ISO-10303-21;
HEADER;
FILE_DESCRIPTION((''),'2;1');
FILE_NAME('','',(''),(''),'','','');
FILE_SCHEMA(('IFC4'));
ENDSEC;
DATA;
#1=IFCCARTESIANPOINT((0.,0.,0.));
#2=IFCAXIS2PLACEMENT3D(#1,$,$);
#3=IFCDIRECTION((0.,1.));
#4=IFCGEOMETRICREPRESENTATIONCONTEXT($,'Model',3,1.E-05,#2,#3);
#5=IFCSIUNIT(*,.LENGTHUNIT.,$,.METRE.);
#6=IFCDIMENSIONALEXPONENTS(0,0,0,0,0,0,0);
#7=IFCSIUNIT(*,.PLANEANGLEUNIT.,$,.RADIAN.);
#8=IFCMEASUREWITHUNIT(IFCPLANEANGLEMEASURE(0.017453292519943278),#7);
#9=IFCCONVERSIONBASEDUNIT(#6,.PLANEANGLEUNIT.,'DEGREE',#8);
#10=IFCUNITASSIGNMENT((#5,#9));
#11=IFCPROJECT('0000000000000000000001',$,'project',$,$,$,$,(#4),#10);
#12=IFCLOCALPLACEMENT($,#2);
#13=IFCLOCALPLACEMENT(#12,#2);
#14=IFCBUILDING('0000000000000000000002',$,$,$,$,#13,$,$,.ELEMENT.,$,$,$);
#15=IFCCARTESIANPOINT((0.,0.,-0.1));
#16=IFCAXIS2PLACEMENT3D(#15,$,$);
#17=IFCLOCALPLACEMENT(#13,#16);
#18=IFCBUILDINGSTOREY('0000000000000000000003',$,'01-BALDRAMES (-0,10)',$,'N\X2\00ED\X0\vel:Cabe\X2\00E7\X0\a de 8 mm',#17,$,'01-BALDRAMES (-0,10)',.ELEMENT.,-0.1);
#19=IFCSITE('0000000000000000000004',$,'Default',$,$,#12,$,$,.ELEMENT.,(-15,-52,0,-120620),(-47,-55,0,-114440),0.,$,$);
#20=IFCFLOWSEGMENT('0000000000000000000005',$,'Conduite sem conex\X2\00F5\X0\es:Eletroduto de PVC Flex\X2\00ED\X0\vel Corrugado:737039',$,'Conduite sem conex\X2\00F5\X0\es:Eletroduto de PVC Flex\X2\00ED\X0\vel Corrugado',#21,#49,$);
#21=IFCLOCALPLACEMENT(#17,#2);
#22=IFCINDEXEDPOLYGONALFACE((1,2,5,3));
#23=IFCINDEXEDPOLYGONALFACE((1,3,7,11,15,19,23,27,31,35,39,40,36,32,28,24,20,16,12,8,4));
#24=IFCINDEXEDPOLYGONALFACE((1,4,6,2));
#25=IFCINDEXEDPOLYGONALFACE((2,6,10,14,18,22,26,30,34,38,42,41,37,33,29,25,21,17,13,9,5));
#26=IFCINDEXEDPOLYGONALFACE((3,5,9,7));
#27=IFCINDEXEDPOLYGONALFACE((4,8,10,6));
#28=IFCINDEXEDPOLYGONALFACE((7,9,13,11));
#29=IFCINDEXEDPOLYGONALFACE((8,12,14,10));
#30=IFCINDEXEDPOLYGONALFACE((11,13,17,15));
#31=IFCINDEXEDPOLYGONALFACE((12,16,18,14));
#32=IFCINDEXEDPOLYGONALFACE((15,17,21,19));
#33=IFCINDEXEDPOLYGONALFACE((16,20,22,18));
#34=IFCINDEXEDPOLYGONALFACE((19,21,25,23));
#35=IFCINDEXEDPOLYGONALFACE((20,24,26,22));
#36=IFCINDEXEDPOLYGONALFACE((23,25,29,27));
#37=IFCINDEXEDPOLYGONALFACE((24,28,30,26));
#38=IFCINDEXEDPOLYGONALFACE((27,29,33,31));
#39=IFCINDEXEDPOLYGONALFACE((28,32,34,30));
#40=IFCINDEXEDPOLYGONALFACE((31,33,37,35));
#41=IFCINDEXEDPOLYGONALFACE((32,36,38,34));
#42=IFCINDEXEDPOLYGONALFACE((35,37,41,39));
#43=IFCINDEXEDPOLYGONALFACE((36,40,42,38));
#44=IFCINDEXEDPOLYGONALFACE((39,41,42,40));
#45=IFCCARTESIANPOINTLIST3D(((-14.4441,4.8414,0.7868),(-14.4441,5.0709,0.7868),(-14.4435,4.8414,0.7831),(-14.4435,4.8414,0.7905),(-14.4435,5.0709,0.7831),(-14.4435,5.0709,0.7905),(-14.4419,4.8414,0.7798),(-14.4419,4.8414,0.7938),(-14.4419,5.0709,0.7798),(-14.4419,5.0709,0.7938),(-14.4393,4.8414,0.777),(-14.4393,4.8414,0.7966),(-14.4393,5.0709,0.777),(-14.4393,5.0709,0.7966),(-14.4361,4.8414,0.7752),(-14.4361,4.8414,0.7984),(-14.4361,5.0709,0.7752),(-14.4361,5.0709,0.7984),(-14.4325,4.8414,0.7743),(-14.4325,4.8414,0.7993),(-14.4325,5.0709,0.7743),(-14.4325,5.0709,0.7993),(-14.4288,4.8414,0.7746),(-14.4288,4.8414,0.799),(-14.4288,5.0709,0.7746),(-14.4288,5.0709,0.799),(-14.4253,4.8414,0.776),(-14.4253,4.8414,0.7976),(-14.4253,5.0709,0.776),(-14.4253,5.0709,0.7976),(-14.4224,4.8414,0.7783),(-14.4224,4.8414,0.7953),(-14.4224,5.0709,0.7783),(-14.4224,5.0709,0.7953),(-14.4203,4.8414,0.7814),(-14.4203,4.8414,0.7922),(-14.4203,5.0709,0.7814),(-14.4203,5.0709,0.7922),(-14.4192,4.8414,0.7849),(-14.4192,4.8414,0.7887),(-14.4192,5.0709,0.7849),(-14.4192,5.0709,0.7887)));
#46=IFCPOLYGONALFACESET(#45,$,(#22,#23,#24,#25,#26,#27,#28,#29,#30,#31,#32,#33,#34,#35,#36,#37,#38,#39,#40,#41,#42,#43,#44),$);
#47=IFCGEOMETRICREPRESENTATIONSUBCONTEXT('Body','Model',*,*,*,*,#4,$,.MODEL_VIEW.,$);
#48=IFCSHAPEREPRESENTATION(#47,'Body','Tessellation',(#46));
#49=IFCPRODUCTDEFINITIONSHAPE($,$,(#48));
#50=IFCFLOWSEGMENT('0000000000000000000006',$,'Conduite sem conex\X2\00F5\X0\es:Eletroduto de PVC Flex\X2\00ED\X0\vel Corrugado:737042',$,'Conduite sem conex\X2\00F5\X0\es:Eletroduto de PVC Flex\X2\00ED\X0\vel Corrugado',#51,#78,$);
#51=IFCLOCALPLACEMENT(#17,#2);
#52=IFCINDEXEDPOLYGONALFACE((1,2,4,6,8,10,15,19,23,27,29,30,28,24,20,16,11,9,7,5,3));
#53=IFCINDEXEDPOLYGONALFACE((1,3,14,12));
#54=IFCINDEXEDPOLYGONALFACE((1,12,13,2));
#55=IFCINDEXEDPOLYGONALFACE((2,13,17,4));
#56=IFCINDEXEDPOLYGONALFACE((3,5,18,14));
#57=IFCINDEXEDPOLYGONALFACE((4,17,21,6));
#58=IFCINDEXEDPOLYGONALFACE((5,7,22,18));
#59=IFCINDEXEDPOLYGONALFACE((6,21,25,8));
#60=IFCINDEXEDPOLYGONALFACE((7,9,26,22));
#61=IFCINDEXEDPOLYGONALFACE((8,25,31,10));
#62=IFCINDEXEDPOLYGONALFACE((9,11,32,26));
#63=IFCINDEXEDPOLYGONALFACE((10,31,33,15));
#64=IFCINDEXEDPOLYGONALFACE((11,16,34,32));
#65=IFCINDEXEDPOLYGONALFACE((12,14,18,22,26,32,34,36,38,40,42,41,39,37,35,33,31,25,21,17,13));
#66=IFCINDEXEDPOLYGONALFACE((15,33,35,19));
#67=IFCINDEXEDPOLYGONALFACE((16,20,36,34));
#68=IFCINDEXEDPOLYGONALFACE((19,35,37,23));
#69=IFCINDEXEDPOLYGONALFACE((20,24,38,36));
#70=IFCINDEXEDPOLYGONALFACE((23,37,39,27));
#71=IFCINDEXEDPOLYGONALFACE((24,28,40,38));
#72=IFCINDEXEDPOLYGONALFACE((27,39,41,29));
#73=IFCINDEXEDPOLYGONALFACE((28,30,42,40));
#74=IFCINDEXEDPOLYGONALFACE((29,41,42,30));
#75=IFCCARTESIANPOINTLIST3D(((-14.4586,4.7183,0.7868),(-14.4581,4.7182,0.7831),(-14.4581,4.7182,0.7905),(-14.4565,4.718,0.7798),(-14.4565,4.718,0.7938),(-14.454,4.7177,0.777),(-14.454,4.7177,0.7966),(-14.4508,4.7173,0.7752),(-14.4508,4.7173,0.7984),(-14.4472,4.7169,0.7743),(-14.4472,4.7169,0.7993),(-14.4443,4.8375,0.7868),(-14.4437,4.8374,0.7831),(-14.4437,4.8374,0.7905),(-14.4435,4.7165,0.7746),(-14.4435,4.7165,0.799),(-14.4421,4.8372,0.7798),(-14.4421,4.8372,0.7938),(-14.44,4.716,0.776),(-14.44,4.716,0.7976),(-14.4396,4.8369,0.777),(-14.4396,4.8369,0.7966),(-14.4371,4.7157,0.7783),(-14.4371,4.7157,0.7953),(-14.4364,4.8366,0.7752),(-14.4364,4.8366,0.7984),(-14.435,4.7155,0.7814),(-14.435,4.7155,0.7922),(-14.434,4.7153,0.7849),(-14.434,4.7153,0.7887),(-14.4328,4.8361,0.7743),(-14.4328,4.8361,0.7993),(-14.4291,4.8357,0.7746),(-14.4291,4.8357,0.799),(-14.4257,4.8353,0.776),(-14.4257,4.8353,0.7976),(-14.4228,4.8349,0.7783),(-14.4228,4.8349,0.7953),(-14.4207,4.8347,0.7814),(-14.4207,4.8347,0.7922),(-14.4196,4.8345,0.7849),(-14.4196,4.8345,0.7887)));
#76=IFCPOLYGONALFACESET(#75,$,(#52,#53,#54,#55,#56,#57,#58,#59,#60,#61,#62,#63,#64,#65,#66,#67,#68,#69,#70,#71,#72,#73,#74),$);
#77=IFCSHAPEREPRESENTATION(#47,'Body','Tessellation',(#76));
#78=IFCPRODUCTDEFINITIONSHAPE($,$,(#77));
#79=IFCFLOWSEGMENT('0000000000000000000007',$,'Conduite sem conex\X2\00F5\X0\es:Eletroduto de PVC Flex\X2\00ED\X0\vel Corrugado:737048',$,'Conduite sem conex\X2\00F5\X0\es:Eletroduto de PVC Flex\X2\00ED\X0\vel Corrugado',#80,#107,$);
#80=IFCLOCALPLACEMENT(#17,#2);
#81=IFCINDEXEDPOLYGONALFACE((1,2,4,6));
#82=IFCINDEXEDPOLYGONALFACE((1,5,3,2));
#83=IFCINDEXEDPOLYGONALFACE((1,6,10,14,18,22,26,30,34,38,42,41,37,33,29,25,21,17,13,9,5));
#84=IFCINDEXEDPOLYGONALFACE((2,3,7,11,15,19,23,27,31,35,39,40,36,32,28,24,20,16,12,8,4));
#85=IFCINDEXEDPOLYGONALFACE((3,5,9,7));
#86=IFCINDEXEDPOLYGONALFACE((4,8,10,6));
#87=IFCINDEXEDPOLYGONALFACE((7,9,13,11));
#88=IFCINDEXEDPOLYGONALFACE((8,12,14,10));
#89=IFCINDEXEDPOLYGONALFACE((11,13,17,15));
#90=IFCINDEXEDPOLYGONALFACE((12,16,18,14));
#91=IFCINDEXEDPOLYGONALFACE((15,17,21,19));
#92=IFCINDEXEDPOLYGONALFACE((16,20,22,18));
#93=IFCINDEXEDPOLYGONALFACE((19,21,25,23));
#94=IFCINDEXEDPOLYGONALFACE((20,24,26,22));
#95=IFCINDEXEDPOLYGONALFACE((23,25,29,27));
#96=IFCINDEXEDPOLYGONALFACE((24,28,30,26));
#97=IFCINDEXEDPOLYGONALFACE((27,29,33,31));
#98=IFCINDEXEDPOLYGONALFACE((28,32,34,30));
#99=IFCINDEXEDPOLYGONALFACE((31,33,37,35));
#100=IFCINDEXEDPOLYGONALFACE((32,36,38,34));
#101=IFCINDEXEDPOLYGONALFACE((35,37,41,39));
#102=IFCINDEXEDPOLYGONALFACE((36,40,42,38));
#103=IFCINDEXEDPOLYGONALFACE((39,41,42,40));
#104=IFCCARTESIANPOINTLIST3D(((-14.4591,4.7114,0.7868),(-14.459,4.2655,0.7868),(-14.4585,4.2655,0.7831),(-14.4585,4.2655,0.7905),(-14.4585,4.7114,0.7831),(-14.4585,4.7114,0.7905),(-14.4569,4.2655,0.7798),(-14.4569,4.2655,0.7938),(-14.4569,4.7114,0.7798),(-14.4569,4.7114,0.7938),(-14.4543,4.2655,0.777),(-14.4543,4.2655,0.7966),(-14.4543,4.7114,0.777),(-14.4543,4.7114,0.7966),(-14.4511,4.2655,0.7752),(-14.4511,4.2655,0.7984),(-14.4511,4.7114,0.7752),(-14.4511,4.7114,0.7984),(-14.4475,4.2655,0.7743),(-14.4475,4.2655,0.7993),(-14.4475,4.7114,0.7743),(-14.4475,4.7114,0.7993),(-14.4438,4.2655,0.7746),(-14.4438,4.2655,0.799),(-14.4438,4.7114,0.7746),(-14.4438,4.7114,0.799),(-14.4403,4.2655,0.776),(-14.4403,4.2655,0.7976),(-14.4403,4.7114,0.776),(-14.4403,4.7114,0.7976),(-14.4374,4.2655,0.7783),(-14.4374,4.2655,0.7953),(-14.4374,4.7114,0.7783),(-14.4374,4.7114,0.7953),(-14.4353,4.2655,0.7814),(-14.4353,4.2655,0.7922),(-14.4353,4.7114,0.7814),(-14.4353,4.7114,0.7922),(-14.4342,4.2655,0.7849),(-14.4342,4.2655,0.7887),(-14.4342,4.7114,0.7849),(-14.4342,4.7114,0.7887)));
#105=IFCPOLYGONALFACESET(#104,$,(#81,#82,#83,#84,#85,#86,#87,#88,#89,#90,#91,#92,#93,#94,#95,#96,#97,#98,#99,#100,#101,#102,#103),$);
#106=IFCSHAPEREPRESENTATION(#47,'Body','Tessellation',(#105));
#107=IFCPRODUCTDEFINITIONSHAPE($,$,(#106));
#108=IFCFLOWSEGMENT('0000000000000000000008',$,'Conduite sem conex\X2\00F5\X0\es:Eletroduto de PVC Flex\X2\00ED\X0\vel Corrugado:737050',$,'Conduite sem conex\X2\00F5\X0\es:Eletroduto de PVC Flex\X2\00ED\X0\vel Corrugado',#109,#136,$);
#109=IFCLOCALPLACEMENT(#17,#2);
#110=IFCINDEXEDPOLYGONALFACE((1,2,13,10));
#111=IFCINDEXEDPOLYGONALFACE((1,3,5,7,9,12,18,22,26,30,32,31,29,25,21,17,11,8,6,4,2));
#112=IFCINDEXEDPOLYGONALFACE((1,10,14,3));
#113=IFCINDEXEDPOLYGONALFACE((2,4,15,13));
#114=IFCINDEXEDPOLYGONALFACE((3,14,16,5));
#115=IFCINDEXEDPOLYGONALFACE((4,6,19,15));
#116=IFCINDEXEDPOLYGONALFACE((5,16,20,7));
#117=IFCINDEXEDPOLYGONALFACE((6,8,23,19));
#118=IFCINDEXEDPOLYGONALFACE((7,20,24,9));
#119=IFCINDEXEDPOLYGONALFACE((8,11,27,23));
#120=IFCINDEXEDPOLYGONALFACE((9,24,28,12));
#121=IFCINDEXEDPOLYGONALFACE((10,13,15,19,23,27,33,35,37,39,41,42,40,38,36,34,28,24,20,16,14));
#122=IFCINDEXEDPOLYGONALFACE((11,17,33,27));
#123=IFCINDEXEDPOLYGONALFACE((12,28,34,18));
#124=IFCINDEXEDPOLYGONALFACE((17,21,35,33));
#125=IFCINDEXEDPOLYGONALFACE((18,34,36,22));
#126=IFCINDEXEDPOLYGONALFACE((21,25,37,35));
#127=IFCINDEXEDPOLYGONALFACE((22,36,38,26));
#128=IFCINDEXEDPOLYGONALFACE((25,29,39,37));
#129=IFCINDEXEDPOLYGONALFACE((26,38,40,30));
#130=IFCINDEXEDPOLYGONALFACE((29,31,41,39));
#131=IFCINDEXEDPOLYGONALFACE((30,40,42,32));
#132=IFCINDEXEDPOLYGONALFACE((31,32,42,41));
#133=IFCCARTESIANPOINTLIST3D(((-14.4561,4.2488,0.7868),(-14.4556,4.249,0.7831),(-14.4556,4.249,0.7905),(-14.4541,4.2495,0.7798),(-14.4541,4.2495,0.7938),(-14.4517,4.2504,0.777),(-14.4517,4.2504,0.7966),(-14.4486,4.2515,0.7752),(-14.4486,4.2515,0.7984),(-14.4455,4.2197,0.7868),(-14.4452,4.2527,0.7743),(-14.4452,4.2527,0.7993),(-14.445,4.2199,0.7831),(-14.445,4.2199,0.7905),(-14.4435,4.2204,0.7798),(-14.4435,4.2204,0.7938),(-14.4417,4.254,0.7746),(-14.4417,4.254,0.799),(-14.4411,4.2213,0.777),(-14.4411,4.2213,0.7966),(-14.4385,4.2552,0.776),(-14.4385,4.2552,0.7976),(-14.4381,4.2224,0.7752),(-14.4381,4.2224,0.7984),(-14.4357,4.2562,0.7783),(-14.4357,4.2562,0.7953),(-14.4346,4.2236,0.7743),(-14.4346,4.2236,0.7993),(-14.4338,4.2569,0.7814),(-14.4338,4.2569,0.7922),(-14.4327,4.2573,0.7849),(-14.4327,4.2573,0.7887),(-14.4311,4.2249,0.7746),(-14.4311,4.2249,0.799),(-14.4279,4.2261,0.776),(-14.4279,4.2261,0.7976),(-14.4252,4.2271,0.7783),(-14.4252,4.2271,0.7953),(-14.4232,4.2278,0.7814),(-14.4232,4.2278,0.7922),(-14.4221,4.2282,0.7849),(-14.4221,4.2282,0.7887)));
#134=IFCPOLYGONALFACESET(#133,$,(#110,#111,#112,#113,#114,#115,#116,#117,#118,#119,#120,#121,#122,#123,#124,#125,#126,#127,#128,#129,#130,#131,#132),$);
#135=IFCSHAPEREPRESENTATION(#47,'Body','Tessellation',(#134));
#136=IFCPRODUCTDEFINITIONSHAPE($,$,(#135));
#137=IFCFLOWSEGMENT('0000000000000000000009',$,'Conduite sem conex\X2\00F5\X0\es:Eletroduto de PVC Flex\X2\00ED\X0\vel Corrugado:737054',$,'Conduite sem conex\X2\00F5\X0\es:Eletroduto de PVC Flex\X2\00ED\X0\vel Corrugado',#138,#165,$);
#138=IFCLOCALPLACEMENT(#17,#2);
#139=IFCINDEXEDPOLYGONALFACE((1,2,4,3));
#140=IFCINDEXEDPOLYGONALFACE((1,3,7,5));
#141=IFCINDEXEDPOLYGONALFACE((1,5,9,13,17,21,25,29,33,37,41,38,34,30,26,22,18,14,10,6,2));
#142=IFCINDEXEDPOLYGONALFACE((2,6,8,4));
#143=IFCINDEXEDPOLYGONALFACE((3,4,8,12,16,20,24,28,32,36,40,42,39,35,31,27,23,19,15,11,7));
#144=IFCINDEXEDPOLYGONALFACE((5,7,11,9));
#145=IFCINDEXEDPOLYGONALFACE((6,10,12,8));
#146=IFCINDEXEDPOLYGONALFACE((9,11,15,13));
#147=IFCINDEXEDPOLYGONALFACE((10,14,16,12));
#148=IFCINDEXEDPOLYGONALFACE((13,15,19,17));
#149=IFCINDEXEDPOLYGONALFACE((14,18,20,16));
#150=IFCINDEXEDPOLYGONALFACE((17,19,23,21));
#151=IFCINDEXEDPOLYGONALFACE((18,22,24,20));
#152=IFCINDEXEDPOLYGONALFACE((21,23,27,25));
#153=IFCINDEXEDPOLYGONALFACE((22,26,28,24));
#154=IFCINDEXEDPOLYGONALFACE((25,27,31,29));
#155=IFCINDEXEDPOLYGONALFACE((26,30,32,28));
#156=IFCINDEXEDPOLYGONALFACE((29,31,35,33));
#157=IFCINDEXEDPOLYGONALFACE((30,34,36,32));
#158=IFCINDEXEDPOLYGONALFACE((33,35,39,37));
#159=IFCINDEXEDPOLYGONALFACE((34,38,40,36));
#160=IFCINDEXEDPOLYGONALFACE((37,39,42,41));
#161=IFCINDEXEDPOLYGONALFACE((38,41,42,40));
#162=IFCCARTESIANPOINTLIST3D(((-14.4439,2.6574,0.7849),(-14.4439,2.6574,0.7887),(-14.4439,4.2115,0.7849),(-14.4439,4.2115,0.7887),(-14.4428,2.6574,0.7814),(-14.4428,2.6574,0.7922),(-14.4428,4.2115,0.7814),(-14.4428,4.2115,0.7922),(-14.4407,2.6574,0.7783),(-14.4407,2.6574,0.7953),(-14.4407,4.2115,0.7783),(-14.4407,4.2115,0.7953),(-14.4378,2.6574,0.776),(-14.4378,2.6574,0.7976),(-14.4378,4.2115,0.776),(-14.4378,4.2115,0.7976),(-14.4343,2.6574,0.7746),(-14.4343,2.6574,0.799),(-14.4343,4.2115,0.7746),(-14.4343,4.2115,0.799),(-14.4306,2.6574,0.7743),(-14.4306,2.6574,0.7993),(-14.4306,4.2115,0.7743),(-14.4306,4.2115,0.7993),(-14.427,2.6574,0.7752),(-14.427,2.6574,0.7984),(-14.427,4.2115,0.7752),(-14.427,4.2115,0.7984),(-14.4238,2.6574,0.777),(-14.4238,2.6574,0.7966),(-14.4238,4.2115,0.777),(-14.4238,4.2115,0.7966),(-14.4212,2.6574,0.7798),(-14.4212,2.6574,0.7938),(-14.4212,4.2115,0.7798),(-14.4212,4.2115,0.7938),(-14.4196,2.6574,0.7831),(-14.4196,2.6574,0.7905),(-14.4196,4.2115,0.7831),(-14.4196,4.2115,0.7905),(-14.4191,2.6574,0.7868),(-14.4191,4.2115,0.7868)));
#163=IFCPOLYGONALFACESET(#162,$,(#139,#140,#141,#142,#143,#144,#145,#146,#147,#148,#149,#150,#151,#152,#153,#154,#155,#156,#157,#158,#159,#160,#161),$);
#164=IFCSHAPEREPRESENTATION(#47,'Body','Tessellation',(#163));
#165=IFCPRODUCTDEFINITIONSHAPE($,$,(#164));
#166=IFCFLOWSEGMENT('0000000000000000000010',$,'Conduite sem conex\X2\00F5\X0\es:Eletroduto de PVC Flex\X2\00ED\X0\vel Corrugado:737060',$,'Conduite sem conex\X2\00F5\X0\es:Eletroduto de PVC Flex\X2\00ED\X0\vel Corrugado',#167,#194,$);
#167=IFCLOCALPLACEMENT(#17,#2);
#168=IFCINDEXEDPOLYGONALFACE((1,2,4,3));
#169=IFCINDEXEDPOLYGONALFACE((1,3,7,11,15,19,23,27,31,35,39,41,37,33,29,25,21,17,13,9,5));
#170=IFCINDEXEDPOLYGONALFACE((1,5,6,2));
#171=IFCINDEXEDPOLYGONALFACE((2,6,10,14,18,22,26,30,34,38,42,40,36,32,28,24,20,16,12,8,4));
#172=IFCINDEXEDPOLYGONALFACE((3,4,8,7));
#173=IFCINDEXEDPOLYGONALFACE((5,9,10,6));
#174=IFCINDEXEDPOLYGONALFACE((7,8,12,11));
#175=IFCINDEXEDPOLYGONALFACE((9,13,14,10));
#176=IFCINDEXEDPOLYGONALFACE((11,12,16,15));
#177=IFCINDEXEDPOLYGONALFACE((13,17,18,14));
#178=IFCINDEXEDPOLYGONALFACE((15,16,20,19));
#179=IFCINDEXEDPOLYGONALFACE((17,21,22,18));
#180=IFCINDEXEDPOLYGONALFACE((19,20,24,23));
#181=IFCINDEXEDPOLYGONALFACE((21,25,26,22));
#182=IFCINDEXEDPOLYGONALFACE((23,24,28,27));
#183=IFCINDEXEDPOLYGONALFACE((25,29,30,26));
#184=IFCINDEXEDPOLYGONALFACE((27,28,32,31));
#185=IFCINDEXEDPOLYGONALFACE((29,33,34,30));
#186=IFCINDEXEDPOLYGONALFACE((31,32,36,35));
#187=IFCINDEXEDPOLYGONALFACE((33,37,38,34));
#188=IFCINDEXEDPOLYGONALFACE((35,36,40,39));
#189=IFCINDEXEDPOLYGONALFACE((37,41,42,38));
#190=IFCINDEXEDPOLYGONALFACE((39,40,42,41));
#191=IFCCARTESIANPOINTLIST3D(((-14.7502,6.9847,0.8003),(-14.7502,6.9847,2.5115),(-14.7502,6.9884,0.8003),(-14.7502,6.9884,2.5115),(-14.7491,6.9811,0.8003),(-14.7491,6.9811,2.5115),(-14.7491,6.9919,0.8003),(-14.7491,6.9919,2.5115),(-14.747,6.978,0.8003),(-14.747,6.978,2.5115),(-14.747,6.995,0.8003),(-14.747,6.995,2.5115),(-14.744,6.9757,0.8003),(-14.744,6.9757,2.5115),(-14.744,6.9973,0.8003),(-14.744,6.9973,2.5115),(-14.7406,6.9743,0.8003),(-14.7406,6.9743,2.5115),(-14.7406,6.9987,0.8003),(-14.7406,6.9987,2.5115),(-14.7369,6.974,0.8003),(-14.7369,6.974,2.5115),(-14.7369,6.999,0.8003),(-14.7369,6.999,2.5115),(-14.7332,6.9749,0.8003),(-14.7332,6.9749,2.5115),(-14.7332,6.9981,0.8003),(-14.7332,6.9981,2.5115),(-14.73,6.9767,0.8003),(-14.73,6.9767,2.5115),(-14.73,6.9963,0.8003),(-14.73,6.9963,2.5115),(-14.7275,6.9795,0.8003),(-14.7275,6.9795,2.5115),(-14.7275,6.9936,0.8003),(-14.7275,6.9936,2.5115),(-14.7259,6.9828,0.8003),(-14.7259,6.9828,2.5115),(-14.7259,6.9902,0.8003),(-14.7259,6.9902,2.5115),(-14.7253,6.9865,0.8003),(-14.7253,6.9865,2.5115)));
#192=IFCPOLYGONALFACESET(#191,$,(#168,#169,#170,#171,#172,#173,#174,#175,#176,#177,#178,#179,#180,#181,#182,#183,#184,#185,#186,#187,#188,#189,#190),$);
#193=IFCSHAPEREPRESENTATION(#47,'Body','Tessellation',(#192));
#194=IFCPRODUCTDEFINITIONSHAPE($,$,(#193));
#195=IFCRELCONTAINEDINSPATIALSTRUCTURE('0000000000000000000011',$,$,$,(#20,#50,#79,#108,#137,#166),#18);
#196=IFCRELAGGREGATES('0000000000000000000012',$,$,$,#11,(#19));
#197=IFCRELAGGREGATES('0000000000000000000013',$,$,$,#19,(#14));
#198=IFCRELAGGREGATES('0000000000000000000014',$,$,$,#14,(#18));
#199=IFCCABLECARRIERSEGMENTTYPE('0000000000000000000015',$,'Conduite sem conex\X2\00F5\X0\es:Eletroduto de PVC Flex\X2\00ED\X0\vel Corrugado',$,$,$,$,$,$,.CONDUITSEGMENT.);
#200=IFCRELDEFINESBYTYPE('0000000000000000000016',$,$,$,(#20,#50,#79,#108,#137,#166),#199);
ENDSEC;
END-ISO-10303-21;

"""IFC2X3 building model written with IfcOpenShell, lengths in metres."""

from ifc_helpers import new_model, entity, si_unit, converted_unit, direction, frame, frame_2d, origin, origin_2d_with_axis, place, context, subcontext, project, spatial, circle, extrude, type_object, element, save


model = new_model("IFC2X3")

# Units and contexts
model_context = context("Model", 3, precision=1e-05, world=origin(), true_north=direction((0.0, 1.0)))
body_context = subcontext(model_context, "Body", "Model", "MODEL_VIEW")
ifc_project = project(units=[si_unit("LENGTHUNIT", "METRE"), converted_unit("PLANEANGLEUNIT", "DEGREE", entity("IfcPlaneAngleMeasure", 0.017453292519943278), si_unit("PLANEANGLEUNIT", "RADIAN"), dimensions=[0, 0, 0, 0, 0, 0, 0])], contexts=[model_context])

# Site, building, storey
site_placement = place(None, origin())
site = spatial("IfcSite", under=ifc_project, at=site_placement, Name="Default", CompositionType="ELEMENT", RefLatitude=(-15, -52, 0, -120620), RefLongitude=(-47, -55, 0, -114440), RefElevation=0.0)
building_placement = place(site_placement, origin())
building = spatial("IfcBuilding", under=site, at=building_placement, CompositionType="ELEMENT")
storey_placement = place(building_placement, frame((0.0, 0.0, -0.1)))
storey = spatial("IfcBuildingStorey", under=building, at=storey_placement, Name="01-BALDRAMES (-0,10)", ObjectType="Nível:Cabeça de 8 mm", LongName="01-BALDRAMES (-0,10)", CompositionType="ELEMENT", Elevation=-0.1)

# Flow segments
cable_carrier_segment_type = type_object("IfcCableCarrierSegmentType", Name="Conduite sem conexões:Eletroduto de PVC Flexível Corrugado", PredefinedType="CONDUITSEGMENT")
flow_segment_1_placement = place(storey_placement, origin())
element("IfcFlowSegment", 1, at=flow_segment_1_placement, inside=storey, type_object=cable_carrier_segment_type, Name="Conduite sem conexões:Eletroduto de PVC Flexível Corrugado:737039", ObjectType="Conduite sem conexões:Eletroduto de PVC Flexível Corrugado", context=body_context, shape_type="SweptSolid", body=[
    extrude(circle(Radius=0.0125, at=frame_2d((0.0, 0.0), x_axis=(1.0, 0.0))), frame((-14.4316, 4.8414, 0.7868), z_axis=(0.0, 1.0, 0.0), x_axis=(-1.0, 0.0, 0.0)), (0.0, 0.0, 1.0), 0.2295),
])
flow_segment_2_placement = place(storey_placement, origin())
element("IfcFlowSegment", 2, at=flow_segment_2_placement, inside=storey, type_object=cable_carrier_segment_type, Name="Conduite sem conexões:Eletroduto de PVC Flexível Corrugado:737042", ObjectType="Conduite sem conexões:Eletroduto de PVC Flexível Corrugado", context=body_context, shape_type="SweptSolid", body=[
    extrude(circle(Radius=0.0125, at=frame_2d((0.0, 0.0), x_axis=(1.0, 0.0))), frame((-14.4462, 4.7168, 0.7868), z_axis=(0.119527, 0.992831, 0.0), x_axis=(-0.992831, 0.119527, 0.0)), (0.0, 0.0, 1.0), 0.1201),
])
flow_segment_3_placement = place(storey_placement, origin())
element("IfcFlowSegment", 3, at=flow_segment_3_placement, inside=storey, type_object=cable_carrier_segment_type, Name="Conduite sem conexões:Eletroduto de PVC Flexível Corrugado:737048", ObjectType="Conduite sem conexões:Eletroduto de PVC Flexível Corrugado", context=body_context, shape_type="SweptSolid", body=[
    extrude(circle(Radius=0.0125, at=origin_2d_with_axis()), frame((-14.4465, 4.2655, 0.7868), z_axis=(-0.000013, 1.0, 0.0), x_axis=(-1.0, -0.000013, 0.0)), (0.0, 0.0, 1.0), 0.4458),
])
flow_segment_4_placement = place(storey_placement, origin())
element("IfcFlowSegment", 4, at=flow_segment_4_placement, inside=storey, type_object=cable_carrier_segment_type, Name="Conduite sem conexões:Eletroduto de PVC Flexível Corrugado:737050", ObjectType="Conduite sem conexões:Eletroduto de PVC Flexível Corrugado", context=body_context, shape_type="SweptSolid", body=[
    extrude(circle(Radius=0.0125, at=frame_2d((0.0, 0.0), x_axis=(1.0, 0.0))), frame((-14.4338, 4.224, 0.7868), z_axis=(-0.34202, 0.939693, 0.0), x_axis=(-0.939693, -0.34202, 0.0)), (0.0, 0.0, 1.0), 0.0309),
])
flow_segment_5_placement = place(storey_placement, origin())
element("IfcFlowSegment", 5, at=flow_segment_5_placement, inside=storey, type_object=cable_carrier_segment_type, Name="Conduite sem conexões:Eletroduto de PVC Flexível Corrugado:737054", ObjectType="Conduite sem conexões:Eletroduto de PVC Flexível Corrugado", context=body_context, shape_type="SweptSolid", body=[
    extrude(circle(Radius=0.0125, at=frame_2d((0.0, 0.0), x_axis=(1.0, 0.0))), frame((-14.4316, 2.6574, 0.7868), z_axis=(0.0, 1.0, 0.0), x_axis=(1.0, 0.0, 0.0)), (0.0, 0.0, 1.0), 1.554),
])
flow_segment_6_placement = place(storey_placement, origin())
element("IfcFlowSegment", 6, at=flow_segment_6_placement, inside=storey, type_object=cable_carrier_segment_type, Name="Conduite sem conexões:Eletroduto de PVC Flexível Corrugado:737060", ObjectType="Conduite sem conexões:Eletroduto de PVC Flexível Corrugado", context=body_context, shape_type="SweptSolid", body=[
    extrude(circle(Radius=0.0125, at=frame_2d((0.0, 0.0), x_axis=(1.0, 0.0))), frame((-14.7378, 6.9865, 0.8003)), (0.0, 0.0, 1.0), 1.7112),
])

save(model, "model.ifc")
